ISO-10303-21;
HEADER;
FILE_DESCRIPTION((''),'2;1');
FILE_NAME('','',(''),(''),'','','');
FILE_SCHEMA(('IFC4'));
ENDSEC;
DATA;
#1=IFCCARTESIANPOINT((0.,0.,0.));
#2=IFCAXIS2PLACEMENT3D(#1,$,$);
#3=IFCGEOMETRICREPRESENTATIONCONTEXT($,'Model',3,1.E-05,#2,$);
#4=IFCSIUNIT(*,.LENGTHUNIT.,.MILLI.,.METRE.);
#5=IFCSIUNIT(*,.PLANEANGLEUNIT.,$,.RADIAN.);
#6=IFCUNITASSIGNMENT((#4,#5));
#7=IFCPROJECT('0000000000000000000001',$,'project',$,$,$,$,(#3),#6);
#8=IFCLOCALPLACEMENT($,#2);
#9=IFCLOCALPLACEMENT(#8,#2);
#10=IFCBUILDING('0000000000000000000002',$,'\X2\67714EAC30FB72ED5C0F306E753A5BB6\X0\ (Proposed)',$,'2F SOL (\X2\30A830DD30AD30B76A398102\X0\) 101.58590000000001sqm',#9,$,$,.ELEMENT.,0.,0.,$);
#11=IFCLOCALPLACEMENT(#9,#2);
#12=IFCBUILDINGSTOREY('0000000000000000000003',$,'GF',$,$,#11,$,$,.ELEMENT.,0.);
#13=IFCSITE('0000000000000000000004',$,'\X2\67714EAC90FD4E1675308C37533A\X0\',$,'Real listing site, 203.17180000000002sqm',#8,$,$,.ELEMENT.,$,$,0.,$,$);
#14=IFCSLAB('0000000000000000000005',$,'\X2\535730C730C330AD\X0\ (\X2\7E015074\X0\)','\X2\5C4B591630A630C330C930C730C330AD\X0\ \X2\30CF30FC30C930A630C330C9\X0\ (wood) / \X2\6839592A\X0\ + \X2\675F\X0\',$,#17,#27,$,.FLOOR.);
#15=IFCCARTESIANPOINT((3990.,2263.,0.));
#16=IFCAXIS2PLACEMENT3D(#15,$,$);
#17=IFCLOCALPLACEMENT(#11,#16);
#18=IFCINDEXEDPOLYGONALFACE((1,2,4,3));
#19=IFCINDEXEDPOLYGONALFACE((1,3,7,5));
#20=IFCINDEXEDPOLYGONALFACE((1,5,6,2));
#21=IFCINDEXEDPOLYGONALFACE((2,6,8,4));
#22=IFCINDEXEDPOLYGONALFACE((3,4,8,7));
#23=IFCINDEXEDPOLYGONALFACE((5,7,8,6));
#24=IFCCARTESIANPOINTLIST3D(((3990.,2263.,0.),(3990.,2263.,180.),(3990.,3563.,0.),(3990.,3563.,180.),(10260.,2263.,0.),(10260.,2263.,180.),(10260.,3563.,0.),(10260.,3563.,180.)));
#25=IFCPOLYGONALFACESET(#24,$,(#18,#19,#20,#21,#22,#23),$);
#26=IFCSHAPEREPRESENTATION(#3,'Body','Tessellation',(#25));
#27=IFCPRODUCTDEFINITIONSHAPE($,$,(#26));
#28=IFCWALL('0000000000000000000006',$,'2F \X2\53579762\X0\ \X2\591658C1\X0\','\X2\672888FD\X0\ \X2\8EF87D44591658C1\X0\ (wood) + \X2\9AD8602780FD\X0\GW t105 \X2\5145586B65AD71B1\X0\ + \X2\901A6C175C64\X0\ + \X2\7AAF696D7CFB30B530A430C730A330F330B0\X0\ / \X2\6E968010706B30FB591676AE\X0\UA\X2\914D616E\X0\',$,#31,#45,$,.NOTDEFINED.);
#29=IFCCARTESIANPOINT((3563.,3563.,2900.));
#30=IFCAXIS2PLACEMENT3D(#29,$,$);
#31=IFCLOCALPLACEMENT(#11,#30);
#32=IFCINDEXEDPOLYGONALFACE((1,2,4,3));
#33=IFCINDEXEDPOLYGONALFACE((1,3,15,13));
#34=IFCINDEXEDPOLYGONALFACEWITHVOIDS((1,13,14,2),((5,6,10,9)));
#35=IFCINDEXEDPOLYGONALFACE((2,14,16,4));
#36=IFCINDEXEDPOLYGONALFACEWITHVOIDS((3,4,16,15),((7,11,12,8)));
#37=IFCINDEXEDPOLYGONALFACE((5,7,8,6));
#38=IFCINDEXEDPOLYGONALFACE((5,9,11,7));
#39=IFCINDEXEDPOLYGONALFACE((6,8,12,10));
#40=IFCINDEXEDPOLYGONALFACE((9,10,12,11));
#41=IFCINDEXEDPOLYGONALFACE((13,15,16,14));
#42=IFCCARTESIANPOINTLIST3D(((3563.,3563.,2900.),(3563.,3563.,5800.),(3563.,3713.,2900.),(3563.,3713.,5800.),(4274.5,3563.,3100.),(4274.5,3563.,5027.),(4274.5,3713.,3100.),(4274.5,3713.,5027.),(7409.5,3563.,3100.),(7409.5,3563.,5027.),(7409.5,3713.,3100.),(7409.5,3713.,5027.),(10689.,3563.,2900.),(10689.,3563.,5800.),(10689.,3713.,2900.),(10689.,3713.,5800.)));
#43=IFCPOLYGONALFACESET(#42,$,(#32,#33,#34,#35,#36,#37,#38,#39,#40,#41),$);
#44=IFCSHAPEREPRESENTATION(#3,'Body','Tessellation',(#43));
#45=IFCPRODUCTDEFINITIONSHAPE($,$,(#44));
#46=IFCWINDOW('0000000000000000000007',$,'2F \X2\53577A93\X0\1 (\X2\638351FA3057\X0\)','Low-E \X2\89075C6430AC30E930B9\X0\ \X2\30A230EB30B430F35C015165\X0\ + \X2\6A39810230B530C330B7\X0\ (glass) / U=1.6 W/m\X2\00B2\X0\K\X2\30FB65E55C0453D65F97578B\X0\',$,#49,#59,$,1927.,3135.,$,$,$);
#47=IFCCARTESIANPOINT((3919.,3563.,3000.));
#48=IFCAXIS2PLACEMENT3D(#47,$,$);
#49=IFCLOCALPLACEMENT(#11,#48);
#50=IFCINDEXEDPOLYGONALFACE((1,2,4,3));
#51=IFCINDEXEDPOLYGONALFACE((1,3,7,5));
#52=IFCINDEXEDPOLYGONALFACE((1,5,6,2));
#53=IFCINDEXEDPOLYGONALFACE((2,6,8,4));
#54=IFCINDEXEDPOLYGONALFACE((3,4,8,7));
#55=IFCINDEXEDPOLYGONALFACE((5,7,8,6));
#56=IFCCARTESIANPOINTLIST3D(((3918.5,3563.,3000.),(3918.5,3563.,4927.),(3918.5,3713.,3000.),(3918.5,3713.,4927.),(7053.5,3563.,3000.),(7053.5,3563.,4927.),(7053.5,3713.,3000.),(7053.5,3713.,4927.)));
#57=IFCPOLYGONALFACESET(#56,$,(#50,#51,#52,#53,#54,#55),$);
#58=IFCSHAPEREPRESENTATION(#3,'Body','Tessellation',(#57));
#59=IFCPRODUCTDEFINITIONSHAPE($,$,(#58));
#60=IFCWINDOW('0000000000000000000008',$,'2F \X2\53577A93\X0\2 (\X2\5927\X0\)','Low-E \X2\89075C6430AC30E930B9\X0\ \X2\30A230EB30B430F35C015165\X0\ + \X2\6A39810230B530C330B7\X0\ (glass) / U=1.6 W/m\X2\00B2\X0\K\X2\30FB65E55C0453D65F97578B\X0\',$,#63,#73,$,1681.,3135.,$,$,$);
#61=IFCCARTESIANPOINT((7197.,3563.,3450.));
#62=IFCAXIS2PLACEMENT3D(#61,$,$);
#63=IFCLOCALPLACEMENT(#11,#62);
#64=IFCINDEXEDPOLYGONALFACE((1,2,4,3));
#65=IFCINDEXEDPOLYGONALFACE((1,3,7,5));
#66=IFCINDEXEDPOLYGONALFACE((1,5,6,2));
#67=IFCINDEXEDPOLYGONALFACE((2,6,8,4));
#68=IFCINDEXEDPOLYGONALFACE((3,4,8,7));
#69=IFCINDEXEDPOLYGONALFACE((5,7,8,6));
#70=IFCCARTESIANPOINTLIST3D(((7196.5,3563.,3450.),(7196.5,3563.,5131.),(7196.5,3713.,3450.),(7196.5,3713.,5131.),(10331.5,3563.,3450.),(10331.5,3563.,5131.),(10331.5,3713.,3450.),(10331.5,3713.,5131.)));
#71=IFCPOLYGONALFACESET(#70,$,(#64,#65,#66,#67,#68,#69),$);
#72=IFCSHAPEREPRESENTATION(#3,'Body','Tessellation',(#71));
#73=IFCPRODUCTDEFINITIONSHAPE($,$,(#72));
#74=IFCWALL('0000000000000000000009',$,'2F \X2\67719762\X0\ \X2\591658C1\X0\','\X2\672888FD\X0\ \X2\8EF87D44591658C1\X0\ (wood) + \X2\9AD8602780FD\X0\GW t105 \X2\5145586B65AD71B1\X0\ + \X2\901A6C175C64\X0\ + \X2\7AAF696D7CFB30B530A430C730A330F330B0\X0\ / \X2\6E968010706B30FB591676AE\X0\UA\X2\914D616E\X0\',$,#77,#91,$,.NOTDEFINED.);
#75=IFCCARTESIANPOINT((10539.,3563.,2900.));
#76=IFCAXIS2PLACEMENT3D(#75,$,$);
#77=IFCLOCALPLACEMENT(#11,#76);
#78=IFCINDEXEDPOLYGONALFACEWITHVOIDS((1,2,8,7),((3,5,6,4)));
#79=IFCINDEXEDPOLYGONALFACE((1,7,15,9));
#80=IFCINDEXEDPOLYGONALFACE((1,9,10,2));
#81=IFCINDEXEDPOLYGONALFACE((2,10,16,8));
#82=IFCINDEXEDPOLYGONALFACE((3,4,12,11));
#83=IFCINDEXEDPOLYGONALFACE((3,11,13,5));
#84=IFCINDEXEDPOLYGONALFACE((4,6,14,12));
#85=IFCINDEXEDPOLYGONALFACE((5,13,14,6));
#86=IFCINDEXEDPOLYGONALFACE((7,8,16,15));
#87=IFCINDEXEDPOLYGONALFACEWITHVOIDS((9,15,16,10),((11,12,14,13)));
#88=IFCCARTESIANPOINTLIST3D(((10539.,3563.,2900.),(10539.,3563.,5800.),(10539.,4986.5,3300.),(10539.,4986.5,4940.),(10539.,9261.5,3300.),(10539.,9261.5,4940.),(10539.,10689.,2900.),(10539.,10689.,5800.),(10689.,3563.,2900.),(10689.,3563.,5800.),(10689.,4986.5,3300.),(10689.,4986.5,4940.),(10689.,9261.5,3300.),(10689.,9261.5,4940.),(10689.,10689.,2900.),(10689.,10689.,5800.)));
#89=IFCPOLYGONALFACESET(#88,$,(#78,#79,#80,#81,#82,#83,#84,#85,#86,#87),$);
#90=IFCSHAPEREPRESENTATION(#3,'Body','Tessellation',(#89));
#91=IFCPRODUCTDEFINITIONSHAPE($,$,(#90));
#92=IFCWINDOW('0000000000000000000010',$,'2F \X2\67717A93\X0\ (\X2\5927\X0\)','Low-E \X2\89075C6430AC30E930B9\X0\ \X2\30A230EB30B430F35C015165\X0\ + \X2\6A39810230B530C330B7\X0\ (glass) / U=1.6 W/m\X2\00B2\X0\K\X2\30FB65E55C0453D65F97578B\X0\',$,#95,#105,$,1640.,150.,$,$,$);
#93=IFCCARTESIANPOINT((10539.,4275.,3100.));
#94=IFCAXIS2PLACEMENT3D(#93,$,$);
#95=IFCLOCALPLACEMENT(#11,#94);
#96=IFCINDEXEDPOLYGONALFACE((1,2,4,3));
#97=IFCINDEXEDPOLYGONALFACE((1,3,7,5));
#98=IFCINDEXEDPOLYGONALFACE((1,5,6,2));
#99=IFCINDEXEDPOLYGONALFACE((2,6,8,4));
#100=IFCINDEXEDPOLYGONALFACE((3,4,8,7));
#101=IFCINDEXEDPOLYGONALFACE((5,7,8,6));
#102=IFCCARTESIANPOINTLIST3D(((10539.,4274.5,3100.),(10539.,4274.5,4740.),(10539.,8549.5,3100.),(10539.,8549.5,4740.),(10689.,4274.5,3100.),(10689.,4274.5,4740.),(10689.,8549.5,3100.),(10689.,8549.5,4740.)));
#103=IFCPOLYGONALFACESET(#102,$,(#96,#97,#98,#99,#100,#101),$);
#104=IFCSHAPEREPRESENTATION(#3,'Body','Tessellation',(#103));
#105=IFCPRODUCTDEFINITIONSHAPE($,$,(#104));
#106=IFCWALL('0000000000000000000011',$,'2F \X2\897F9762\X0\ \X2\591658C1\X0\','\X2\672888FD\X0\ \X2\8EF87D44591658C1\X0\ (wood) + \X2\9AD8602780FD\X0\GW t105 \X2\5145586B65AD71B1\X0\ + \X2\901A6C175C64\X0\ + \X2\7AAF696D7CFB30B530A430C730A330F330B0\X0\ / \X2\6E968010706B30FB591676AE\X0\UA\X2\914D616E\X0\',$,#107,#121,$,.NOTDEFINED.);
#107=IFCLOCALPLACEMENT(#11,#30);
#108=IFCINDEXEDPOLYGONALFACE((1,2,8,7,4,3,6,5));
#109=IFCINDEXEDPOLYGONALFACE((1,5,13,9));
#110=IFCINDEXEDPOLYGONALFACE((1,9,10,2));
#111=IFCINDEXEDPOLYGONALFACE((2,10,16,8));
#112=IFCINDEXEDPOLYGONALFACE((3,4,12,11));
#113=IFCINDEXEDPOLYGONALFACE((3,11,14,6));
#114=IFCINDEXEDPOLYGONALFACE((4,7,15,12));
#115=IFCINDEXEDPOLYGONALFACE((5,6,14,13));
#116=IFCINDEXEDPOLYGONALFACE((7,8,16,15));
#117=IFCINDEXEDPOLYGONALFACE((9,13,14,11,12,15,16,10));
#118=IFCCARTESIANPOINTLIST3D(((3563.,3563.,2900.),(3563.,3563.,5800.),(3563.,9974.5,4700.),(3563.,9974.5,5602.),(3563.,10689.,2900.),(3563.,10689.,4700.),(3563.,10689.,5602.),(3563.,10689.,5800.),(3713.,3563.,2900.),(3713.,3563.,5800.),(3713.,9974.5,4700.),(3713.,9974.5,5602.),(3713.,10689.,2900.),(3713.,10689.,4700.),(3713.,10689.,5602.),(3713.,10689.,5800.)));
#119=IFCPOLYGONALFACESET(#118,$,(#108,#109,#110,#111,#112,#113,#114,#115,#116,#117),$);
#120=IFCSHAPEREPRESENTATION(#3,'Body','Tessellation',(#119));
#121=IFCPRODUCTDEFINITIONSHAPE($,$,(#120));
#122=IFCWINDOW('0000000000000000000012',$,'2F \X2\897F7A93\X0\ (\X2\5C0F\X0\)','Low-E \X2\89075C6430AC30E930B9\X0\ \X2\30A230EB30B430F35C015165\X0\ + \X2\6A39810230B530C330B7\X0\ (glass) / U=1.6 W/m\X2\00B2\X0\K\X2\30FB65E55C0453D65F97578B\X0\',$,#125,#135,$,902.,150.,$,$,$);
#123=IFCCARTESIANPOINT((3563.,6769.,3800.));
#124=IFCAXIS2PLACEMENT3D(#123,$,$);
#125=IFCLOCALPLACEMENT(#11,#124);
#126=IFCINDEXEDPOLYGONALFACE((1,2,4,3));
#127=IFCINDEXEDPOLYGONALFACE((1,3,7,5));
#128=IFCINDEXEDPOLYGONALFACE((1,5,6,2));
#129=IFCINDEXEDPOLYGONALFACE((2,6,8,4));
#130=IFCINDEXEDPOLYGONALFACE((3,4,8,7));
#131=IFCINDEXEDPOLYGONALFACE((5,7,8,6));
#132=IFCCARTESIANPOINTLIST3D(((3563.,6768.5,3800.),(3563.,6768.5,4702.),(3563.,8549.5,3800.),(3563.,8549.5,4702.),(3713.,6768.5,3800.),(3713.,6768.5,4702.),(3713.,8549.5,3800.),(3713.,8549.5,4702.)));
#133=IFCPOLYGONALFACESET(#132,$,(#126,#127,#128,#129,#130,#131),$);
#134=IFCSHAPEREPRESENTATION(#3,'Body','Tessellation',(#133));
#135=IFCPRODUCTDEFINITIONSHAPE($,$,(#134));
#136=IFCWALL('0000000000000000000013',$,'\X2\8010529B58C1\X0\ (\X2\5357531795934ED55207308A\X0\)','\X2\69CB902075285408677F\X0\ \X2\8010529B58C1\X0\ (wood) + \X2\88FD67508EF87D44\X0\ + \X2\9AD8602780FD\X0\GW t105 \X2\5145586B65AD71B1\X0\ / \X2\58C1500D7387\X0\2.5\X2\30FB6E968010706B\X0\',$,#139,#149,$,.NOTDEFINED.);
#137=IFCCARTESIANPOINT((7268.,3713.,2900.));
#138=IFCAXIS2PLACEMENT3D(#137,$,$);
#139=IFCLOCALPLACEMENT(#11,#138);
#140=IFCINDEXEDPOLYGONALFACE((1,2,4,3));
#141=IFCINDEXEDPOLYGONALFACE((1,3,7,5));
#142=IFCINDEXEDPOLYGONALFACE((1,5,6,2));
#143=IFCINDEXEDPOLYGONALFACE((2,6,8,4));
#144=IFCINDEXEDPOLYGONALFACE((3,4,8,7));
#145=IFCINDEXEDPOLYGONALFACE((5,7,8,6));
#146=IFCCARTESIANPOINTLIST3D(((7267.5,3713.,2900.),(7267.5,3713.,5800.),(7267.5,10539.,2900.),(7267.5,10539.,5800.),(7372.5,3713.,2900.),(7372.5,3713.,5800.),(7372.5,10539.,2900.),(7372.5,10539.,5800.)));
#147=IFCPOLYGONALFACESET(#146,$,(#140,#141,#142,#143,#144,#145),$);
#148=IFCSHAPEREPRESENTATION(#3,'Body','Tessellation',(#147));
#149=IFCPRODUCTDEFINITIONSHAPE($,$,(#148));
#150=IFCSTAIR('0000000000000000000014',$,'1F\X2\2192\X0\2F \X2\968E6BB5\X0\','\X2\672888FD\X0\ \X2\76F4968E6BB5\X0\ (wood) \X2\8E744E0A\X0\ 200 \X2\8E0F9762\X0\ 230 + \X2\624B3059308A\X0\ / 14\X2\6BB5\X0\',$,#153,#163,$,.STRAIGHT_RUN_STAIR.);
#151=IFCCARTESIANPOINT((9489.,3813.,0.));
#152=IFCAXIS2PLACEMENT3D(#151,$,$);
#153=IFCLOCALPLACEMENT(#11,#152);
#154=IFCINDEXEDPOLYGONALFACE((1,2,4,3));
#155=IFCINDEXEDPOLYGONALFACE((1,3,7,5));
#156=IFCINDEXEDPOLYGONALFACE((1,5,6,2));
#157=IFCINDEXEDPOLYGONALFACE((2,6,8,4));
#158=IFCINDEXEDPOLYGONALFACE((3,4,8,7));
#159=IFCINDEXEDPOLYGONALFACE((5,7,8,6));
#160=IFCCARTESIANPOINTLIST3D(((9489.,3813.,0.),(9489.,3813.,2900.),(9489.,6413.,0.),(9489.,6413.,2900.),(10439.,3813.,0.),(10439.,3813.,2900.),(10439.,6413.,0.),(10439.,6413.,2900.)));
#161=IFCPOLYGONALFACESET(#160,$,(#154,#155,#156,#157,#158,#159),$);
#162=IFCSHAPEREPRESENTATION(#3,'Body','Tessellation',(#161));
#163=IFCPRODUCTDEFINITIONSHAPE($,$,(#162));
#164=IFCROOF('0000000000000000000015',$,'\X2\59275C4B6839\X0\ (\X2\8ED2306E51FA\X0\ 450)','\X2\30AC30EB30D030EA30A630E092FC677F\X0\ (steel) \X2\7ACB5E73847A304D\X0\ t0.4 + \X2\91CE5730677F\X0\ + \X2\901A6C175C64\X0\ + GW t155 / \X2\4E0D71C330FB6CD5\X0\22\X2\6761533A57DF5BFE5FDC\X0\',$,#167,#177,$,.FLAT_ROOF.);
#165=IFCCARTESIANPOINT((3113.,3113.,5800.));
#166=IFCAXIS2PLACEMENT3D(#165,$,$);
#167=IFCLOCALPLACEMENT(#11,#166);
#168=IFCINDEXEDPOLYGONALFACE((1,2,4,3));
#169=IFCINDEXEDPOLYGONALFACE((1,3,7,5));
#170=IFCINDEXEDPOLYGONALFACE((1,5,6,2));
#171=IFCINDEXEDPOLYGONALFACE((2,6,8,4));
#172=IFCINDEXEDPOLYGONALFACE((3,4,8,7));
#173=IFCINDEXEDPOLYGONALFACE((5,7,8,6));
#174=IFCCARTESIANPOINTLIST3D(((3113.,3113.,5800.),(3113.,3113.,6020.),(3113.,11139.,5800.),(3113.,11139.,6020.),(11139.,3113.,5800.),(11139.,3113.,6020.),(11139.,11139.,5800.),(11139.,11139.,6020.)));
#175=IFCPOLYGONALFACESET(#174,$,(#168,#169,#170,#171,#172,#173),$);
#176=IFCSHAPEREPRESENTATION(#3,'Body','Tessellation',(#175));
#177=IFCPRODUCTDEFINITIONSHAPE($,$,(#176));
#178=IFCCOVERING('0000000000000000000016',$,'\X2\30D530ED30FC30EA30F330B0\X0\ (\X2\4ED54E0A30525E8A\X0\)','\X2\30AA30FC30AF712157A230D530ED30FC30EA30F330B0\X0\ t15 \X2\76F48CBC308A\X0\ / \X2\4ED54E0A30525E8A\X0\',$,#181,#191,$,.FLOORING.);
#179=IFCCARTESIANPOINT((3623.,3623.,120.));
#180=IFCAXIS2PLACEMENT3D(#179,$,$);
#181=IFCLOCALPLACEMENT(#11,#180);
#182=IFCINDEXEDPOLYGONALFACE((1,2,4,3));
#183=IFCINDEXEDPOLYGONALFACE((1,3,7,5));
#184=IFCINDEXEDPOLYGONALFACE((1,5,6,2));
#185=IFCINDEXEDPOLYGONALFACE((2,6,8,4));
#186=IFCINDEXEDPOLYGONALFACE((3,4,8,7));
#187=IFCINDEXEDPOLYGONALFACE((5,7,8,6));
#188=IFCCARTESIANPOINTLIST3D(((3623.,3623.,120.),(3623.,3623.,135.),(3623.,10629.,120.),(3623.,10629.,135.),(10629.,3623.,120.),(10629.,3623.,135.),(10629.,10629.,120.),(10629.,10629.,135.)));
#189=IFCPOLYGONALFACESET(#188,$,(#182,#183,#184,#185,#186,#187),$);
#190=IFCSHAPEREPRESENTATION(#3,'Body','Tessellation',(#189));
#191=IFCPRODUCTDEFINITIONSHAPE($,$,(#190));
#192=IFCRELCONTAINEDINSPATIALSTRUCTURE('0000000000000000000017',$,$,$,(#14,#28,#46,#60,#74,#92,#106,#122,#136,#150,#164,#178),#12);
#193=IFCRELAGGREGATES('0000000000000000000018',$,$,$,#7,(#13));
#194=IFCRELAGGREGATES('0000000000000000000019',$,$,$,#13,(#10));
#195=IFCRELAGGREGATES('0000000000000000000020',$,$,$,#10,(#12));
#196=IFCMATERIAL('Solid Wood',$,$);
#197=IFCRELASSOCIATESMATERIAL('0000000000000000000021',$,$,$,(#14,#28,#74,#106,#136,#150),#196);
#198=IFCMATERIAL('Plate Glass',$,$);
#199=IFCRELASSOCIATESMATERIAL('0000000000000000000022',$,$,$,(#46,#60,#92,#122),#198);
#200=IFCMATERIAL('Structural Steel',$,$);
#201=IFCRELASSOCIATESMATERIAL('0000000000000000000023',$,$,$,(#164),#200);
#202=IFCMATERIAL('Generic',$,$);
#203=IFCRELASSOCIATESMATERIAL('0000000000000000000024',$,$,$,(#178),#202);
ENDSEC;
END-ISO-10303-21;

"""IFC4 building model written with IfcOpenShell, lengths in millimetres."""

from ifc_helpers import new_model, si_unit, frame, frame_2d, origin, place, context, project, spatial, rectangle, extrude, material, element, fill, save


model = new_model("IFC4")

# Units and contexts
model_context = context("Model", 3, precision=1e-05, world=origin())
ifc_project = project(units=[si_unit("LENGTHUNIT", "METRE", prefix="MILLI"), si_unit("PLANEANGLEUNIT", "RADIAN")], contexts=[model_context])

# Site, building, storey
site_placement = place(None, origin())
site = spatial("IfcSite", under=ifc_project, at=site_placement, Name="東京都世田谷区", ObjectType="Real listing site, 203.17180000000002sqm", CompositionType="ELEMENT", RefElevation=0.0)
building_placement = place(site_placement, origin())
building = spatial("IfcBuilding", under=site, at=building_placement, Name="東京・狭小の町家 (Proposed)", ObjectType="2F SOL (エポキシ樹脂) 101.58590000000001sqm", CompositionType="ELEMENT", ElevationOfRefHeight=0.0, ElevationOfTerrain=0.0)
storey_placement = place(building_placement, origin())
storey = spatial("IfcBuildingStorey", under=building, at=storey_placement, Name="GF", CompositionType="ELEMENT", Elevation=0.0)

# Slab
ifc_material_1 = material(Name="Solid Wood")
slab_1_placement = place(storey_placement, frame((3990.0, 2263.0, 0.0)))
element("IfcSlab", 1, at=slab_1_placement, inside=storey, material=ifc_material_1, Name="南デッキ (縁側)", Description="屋外ウッドデッキ ハードウッド (wood) / 根太 + 束", PredefinedType="FLOOR", context=model_context, shape_type="SweptSolid", body=[
    extrude(rectangle(XDim=6270.0, YDim=1300.0, at=frame_2d((3135.0, 650.0))), frame((3990.0, 2263.0, 0.0)), (0.0, 0.0, 1.0), 180.0),
])

# Shared definitions
ifc_material_2 = material(Name="Plate Glass")

# Wall, openings, windows
wall_1_placement = place(storey_placement, frame((3563.0, 3563.0, 2900.0)))
wall_1 = element("IfcWall", 2, at=wall_1_placement, inside=storey, material=ifc_material_1, Name="2F 南面 外壁", Description="木製 軸組外壁 (wood) + 高性能GW t105 充填断熱 + 通気層 + 窯業系サイディング / 準耐火・外皮UA配慮", PredefinedType="NOTDEFINED", context=model_context, shape_type="SweptSolid", body=[
    extrude(rectangle(XDim=7126.0, YDim=150.0, at=frame_2d((3563.0, 75.0))), frame((3563.0, 3563.0, 2900.0)), (0.0, 0.0, 1.0), 2900.0),
])
opening_1_placement = place(storey_placement, frame((3919.0, 3563.0, 3000.0)))
opening_1 = element("IfcOpeningElement", 3, at=opening_1_placement, cuts=wall_1, PredefinedType="NOTDEFINED", context=model_context, shape_type="SweptSolid", body=[
    extrude(rectangle(XDim=3135.0, YDim=150.0, at=frame_2d((1567.0, 75.0))), frame((3919.0, 3563.0, 3000.0)), (0.0, 0.0, 1.0), 1927.0),
])
opening_2_placement = place(storey_placement, frame((7197.0, 3563.0, 3450.0)))
opening_2 = element("IfcOpeningElement", 4, at=opening_2_placement, cuts=wall_1, PredefinedType="NOTDEFINED", context=model_context, shape_type="SweptSolid", body=[
    extrude(rectangle(XDim=3135.0, YDim=150.0, at=frame_2d((1567.0, 75.0))), frame((7197.0, 3563.0, 3450.0)), (0.0, 0.0, 1.0), 1681.0),
])
window_1_placement = place(storey_placement, frame((3919.0, 3563.0, 3000.0)))
window_1 = element("IfcWindow", 5, at=window_1_placement, inside=storey, material=ifc_material_2, Name="2F 南窓1 (掃出し)", Description="Low-E 複層ガラス アルゴン封入 + 樹脂サッシ (glass) / U=1.6 W/m²K・日射取得型", OverallHeight=1927.0, OverallWidth=3135.0, context=model_context, shape_type="SweptSolid", body=[
    extrude(rectangle(XDim=3135.0, YDim=150.0, at=frame_2d((1567.0, 75.0))), frame((3919.0, 3563.0, 3000.0)), (0.0, 0.0, 1.0), 1927.0),
])
fill(opening_1, window_1)
window_2_placement = place(storey_placement, frame((7197.0, 3563.0, 3450.0)))
window_2 = element("IfcWindow", 6, at=window_2_placement, inside=storey, material=ifc_material_2, Name="2F 南窓2 (大)", Description="Low-E 複層ガラス アルゴン封入 + 樹脂サッシ (glass) / U=1.6 W/m²K・日射取得型", OverallHeight=1681.0, OverallWidth=3135.0, context=model_context, shape_type="SweptSolid", body=[
    extrude(rectangle(XDim=3135.0, YDim=150.0, at=frame_2d((1567.0, 75.0))), frame((7197.0, 3563.0, 3450.0)), (0.0, 0.0, 1.0), 1681.0),
])
fill(opening_2, window_2)

# Walls, openings, windows
wall_2_placement = place(storey_placement, frame((10539.0, 3563.0, 2900.0)))
wall_2 = element("IfcWall", 7, at=wall_2_placement, inside=storey, material=ifc_material_1, Name="2F 東面 外壁", Description="木製 軸組外壁 (wood) + 高性能GW t105 充填断熱 + 通気層 + 窯業系サイディング / 準耐火・外皮UA配慮", PredefinedType="NOTDEFINED", context=model_context, shape_type="SweptSolid", body=[
    extrude(rectangle(XDim=150.0, YDim=7126.0, at=frame_2d((75.0, 3563.0))), frame((10539.0, 3563.0, 2900.0)), (0.0, 0.0, 1.0), 2900.0),
])
opening_3_placement = place(storey_placement, frame((10539.0, 4275.0, 3100.0)))
opening_3 = element("IfcOpeningElement", 8, at=opening_3_placement, cuts=wall_2, PredefinedType="NOTDEFINED", context=model_context, shape_type="SweptSolid", body=[
    extrude(rectangle(XDim=150.0, YDim=4275.0, at=frame_2d((75.0, 2137.0))), frame((10539.0, 4275.0, 3100.0)), (0.0, 0.0, 1.0), 1640.0),
])
window_3_placement = place(storey_placement, frame((10539.0, 4275.0, 3100.0)))
window_3 = element("IfcWindow", 9, at=window_3_placement, inside=storey, material=ifc_material_2, Name="2F 東窓 (大)", Description="Low-E 複層ガラス アルゴン封入 + 樹脂サッシ (glass) / U=1.6 W/m²K・日射取得型", OverallHeight=1640.0, OverallWidth=150.0, context=model_context, shape_type="SweptSolid", body=[
    extrude(rectangle(XDim=150.0, YDim=4275.0, at=frame_2d((75.0, 2137.0))), frame((10539.0, 4275.0, 3100.0)), (0.0, 0.0, 1.0), 1640.0),
])
fill(opening_3, window_3)
wall_3_placement = place(storey_placement, frame((3563.0, 3563.0, 2900.0)))
wall_3 = element("IfcWall", 10, at=wall_3_placement, inside=storey, material=ifc_material_1, Name="2F 西面 外壁", Description="木製 軸組外壁 (wood) + 高性能GW t105 充填断熱 + 通気層 + 窯業系サイディング / 準耐火・外皮UA配慮", PredefinedType="NOTDEFINED", context=model_context, shape_type="SweptSolid", body=[
    extrude(rectangle(XDim=150.0, YDim=7126.0, at=frame_2d((75.0, 3563.0))), frame((3563.0, 3563.0, 2900.0)), (0.0, 0.0, 1.0), 2900.0),
])
opening_4_placement = place(storey_placement, frame((3563.0, 6769.0, 3800.0)))
opening_4 = element("IfcOpeningElement", 11, at=opening_4_placement, cuts=wall_3, PredefinedType="NOTDEFINED", context=model_context, shape_type="SweptSolid", body=[
    extrude(rectangle(XDim=150.0, YDim=1781.0, at=frame_2d((75.0, 890.0))), frame((3563.0, 6769.0, 3800.0)), (0.0, 0.0, 1.0), 902.0),
])
window_4_placement = place(storey_placement, frame((3563.0, 6769.0, 3800.0)))
window_4 = element("IfcWindow", 12, at=window_4_placement, inside=storey, material=ifc_material_2, Name="2F 西窓 (小)", Description="Low-E 複層ガラス アルゴン封入 + 樹脂サッシ (glass) / U=1.6 W/m²K・日射取得型", OverallHeight=902.0, OverallWidth=150.0, context=model_context, shape_type="SweptSolid", body=[
    extrude(rectangle(XDim=150.0, YDim=1781.0, at=frame_2d((75.0, 890.0))), frame((3563.0, 6769.0, 3800.0)), (0.0, 0.0, 1.0), 902.0),
])
fill(opening_4, window_4)

# Wall
wall_4_placement = place(storey_placement, frame((7268.0, 3713.0, 2900.0)))
element("IfcWall", 13, at=wall_4_placement, inside=storey, material=ifc_material_1, Name="耐力壁 (南北間仕切り)", Description="構造用合板 耐力壁 (wood) + 製材軸組 + 高性能GW t105 充填断熱 / 壁倍率2.5・準耐火", PredefinedType="NOTDEFINED", context=model_context, shape_type="SweptSolid", body=[
    extrude(rectangle(XDim=105.0, YDim=6826.0, at=frame_2d((52.0, 3413.0))), frame((7268.0, 3713.0, 2900.0)), (0.0, 0.0, 1.0), 2900.0),
])

# Stair
stair_placement = place(storey_placement, frame((9489.0, 3813.0, 0.0)))
element("IfcStair", 14, at=stair_placement, inside=storey, material=ifc_material_1, Name="1F→2F 階段", Description="木製 直階段 (wood) 蹴上 200 踏面 230 + 手すり / 14段", PredefinedType="STRAIGHT_RUN_STAIR", context=model_context, shape_type="SweptSolid", body=[
    extrude(rectangle(XDim=950.0, YDim=2600.0, at=frame_2d((475.0, 1300.0))), frame((9489.0, 3813.0, 0.0)), (0.0, 0.0, 1.0), 2900.0),
])

# Roof
ifc_material_3 = material(Name="Structural Steel")
roof_placement = place(storey_placement, frame((3113.0, 3113.0, 5800.0)))
element("IfcRoof", 15, at=roof_placement, inside=storey, material=ifc_material_3, Name="大屋根 (軒の出 450)", Description="ガルバリウム鋼板 (steel) 立平葺き t0.4 + 野地板 + 通気層 + GW t155 / 不燃・法22条区域対応", PredefinedType="FLAT_ROOF", context=model_context, shape_type="SweptSolid", body=[
    extrude(rectangle(XDim=8026.0, YDim=8026.0, at=frame_2d((4013.0, 4013.0))), frame((3113.0, 3113.0, 5800.0)), (0.0, 0.0, 1.0), 220.0),
])

# Covering
ifc_material_4 = material(Name="Generic")
covering_1_placement = place(storey_placement, frame((3623.0, 3623.0, 120.0)))
element("IfcCovering", 16, at=covering_1_placement, inside=storey, material=ifc_material_4, Name="フローリング (仕上げ床)", Description="オーク無垢フローリング t15 直貼り / 仕上げ床", PredefinedType="FLOORING", context=model_context, shape_type="SweptSolid", body=[
    extrude(rectangle(XDim=7006.0, YDim=7006.0, at=frame_2d((3503.0, 3503.0))), frame((3623.0, 3623.0, 120.0)), (0.0, 0.0, 1.0), 15.0),
])

save(model, "model.ifc")
